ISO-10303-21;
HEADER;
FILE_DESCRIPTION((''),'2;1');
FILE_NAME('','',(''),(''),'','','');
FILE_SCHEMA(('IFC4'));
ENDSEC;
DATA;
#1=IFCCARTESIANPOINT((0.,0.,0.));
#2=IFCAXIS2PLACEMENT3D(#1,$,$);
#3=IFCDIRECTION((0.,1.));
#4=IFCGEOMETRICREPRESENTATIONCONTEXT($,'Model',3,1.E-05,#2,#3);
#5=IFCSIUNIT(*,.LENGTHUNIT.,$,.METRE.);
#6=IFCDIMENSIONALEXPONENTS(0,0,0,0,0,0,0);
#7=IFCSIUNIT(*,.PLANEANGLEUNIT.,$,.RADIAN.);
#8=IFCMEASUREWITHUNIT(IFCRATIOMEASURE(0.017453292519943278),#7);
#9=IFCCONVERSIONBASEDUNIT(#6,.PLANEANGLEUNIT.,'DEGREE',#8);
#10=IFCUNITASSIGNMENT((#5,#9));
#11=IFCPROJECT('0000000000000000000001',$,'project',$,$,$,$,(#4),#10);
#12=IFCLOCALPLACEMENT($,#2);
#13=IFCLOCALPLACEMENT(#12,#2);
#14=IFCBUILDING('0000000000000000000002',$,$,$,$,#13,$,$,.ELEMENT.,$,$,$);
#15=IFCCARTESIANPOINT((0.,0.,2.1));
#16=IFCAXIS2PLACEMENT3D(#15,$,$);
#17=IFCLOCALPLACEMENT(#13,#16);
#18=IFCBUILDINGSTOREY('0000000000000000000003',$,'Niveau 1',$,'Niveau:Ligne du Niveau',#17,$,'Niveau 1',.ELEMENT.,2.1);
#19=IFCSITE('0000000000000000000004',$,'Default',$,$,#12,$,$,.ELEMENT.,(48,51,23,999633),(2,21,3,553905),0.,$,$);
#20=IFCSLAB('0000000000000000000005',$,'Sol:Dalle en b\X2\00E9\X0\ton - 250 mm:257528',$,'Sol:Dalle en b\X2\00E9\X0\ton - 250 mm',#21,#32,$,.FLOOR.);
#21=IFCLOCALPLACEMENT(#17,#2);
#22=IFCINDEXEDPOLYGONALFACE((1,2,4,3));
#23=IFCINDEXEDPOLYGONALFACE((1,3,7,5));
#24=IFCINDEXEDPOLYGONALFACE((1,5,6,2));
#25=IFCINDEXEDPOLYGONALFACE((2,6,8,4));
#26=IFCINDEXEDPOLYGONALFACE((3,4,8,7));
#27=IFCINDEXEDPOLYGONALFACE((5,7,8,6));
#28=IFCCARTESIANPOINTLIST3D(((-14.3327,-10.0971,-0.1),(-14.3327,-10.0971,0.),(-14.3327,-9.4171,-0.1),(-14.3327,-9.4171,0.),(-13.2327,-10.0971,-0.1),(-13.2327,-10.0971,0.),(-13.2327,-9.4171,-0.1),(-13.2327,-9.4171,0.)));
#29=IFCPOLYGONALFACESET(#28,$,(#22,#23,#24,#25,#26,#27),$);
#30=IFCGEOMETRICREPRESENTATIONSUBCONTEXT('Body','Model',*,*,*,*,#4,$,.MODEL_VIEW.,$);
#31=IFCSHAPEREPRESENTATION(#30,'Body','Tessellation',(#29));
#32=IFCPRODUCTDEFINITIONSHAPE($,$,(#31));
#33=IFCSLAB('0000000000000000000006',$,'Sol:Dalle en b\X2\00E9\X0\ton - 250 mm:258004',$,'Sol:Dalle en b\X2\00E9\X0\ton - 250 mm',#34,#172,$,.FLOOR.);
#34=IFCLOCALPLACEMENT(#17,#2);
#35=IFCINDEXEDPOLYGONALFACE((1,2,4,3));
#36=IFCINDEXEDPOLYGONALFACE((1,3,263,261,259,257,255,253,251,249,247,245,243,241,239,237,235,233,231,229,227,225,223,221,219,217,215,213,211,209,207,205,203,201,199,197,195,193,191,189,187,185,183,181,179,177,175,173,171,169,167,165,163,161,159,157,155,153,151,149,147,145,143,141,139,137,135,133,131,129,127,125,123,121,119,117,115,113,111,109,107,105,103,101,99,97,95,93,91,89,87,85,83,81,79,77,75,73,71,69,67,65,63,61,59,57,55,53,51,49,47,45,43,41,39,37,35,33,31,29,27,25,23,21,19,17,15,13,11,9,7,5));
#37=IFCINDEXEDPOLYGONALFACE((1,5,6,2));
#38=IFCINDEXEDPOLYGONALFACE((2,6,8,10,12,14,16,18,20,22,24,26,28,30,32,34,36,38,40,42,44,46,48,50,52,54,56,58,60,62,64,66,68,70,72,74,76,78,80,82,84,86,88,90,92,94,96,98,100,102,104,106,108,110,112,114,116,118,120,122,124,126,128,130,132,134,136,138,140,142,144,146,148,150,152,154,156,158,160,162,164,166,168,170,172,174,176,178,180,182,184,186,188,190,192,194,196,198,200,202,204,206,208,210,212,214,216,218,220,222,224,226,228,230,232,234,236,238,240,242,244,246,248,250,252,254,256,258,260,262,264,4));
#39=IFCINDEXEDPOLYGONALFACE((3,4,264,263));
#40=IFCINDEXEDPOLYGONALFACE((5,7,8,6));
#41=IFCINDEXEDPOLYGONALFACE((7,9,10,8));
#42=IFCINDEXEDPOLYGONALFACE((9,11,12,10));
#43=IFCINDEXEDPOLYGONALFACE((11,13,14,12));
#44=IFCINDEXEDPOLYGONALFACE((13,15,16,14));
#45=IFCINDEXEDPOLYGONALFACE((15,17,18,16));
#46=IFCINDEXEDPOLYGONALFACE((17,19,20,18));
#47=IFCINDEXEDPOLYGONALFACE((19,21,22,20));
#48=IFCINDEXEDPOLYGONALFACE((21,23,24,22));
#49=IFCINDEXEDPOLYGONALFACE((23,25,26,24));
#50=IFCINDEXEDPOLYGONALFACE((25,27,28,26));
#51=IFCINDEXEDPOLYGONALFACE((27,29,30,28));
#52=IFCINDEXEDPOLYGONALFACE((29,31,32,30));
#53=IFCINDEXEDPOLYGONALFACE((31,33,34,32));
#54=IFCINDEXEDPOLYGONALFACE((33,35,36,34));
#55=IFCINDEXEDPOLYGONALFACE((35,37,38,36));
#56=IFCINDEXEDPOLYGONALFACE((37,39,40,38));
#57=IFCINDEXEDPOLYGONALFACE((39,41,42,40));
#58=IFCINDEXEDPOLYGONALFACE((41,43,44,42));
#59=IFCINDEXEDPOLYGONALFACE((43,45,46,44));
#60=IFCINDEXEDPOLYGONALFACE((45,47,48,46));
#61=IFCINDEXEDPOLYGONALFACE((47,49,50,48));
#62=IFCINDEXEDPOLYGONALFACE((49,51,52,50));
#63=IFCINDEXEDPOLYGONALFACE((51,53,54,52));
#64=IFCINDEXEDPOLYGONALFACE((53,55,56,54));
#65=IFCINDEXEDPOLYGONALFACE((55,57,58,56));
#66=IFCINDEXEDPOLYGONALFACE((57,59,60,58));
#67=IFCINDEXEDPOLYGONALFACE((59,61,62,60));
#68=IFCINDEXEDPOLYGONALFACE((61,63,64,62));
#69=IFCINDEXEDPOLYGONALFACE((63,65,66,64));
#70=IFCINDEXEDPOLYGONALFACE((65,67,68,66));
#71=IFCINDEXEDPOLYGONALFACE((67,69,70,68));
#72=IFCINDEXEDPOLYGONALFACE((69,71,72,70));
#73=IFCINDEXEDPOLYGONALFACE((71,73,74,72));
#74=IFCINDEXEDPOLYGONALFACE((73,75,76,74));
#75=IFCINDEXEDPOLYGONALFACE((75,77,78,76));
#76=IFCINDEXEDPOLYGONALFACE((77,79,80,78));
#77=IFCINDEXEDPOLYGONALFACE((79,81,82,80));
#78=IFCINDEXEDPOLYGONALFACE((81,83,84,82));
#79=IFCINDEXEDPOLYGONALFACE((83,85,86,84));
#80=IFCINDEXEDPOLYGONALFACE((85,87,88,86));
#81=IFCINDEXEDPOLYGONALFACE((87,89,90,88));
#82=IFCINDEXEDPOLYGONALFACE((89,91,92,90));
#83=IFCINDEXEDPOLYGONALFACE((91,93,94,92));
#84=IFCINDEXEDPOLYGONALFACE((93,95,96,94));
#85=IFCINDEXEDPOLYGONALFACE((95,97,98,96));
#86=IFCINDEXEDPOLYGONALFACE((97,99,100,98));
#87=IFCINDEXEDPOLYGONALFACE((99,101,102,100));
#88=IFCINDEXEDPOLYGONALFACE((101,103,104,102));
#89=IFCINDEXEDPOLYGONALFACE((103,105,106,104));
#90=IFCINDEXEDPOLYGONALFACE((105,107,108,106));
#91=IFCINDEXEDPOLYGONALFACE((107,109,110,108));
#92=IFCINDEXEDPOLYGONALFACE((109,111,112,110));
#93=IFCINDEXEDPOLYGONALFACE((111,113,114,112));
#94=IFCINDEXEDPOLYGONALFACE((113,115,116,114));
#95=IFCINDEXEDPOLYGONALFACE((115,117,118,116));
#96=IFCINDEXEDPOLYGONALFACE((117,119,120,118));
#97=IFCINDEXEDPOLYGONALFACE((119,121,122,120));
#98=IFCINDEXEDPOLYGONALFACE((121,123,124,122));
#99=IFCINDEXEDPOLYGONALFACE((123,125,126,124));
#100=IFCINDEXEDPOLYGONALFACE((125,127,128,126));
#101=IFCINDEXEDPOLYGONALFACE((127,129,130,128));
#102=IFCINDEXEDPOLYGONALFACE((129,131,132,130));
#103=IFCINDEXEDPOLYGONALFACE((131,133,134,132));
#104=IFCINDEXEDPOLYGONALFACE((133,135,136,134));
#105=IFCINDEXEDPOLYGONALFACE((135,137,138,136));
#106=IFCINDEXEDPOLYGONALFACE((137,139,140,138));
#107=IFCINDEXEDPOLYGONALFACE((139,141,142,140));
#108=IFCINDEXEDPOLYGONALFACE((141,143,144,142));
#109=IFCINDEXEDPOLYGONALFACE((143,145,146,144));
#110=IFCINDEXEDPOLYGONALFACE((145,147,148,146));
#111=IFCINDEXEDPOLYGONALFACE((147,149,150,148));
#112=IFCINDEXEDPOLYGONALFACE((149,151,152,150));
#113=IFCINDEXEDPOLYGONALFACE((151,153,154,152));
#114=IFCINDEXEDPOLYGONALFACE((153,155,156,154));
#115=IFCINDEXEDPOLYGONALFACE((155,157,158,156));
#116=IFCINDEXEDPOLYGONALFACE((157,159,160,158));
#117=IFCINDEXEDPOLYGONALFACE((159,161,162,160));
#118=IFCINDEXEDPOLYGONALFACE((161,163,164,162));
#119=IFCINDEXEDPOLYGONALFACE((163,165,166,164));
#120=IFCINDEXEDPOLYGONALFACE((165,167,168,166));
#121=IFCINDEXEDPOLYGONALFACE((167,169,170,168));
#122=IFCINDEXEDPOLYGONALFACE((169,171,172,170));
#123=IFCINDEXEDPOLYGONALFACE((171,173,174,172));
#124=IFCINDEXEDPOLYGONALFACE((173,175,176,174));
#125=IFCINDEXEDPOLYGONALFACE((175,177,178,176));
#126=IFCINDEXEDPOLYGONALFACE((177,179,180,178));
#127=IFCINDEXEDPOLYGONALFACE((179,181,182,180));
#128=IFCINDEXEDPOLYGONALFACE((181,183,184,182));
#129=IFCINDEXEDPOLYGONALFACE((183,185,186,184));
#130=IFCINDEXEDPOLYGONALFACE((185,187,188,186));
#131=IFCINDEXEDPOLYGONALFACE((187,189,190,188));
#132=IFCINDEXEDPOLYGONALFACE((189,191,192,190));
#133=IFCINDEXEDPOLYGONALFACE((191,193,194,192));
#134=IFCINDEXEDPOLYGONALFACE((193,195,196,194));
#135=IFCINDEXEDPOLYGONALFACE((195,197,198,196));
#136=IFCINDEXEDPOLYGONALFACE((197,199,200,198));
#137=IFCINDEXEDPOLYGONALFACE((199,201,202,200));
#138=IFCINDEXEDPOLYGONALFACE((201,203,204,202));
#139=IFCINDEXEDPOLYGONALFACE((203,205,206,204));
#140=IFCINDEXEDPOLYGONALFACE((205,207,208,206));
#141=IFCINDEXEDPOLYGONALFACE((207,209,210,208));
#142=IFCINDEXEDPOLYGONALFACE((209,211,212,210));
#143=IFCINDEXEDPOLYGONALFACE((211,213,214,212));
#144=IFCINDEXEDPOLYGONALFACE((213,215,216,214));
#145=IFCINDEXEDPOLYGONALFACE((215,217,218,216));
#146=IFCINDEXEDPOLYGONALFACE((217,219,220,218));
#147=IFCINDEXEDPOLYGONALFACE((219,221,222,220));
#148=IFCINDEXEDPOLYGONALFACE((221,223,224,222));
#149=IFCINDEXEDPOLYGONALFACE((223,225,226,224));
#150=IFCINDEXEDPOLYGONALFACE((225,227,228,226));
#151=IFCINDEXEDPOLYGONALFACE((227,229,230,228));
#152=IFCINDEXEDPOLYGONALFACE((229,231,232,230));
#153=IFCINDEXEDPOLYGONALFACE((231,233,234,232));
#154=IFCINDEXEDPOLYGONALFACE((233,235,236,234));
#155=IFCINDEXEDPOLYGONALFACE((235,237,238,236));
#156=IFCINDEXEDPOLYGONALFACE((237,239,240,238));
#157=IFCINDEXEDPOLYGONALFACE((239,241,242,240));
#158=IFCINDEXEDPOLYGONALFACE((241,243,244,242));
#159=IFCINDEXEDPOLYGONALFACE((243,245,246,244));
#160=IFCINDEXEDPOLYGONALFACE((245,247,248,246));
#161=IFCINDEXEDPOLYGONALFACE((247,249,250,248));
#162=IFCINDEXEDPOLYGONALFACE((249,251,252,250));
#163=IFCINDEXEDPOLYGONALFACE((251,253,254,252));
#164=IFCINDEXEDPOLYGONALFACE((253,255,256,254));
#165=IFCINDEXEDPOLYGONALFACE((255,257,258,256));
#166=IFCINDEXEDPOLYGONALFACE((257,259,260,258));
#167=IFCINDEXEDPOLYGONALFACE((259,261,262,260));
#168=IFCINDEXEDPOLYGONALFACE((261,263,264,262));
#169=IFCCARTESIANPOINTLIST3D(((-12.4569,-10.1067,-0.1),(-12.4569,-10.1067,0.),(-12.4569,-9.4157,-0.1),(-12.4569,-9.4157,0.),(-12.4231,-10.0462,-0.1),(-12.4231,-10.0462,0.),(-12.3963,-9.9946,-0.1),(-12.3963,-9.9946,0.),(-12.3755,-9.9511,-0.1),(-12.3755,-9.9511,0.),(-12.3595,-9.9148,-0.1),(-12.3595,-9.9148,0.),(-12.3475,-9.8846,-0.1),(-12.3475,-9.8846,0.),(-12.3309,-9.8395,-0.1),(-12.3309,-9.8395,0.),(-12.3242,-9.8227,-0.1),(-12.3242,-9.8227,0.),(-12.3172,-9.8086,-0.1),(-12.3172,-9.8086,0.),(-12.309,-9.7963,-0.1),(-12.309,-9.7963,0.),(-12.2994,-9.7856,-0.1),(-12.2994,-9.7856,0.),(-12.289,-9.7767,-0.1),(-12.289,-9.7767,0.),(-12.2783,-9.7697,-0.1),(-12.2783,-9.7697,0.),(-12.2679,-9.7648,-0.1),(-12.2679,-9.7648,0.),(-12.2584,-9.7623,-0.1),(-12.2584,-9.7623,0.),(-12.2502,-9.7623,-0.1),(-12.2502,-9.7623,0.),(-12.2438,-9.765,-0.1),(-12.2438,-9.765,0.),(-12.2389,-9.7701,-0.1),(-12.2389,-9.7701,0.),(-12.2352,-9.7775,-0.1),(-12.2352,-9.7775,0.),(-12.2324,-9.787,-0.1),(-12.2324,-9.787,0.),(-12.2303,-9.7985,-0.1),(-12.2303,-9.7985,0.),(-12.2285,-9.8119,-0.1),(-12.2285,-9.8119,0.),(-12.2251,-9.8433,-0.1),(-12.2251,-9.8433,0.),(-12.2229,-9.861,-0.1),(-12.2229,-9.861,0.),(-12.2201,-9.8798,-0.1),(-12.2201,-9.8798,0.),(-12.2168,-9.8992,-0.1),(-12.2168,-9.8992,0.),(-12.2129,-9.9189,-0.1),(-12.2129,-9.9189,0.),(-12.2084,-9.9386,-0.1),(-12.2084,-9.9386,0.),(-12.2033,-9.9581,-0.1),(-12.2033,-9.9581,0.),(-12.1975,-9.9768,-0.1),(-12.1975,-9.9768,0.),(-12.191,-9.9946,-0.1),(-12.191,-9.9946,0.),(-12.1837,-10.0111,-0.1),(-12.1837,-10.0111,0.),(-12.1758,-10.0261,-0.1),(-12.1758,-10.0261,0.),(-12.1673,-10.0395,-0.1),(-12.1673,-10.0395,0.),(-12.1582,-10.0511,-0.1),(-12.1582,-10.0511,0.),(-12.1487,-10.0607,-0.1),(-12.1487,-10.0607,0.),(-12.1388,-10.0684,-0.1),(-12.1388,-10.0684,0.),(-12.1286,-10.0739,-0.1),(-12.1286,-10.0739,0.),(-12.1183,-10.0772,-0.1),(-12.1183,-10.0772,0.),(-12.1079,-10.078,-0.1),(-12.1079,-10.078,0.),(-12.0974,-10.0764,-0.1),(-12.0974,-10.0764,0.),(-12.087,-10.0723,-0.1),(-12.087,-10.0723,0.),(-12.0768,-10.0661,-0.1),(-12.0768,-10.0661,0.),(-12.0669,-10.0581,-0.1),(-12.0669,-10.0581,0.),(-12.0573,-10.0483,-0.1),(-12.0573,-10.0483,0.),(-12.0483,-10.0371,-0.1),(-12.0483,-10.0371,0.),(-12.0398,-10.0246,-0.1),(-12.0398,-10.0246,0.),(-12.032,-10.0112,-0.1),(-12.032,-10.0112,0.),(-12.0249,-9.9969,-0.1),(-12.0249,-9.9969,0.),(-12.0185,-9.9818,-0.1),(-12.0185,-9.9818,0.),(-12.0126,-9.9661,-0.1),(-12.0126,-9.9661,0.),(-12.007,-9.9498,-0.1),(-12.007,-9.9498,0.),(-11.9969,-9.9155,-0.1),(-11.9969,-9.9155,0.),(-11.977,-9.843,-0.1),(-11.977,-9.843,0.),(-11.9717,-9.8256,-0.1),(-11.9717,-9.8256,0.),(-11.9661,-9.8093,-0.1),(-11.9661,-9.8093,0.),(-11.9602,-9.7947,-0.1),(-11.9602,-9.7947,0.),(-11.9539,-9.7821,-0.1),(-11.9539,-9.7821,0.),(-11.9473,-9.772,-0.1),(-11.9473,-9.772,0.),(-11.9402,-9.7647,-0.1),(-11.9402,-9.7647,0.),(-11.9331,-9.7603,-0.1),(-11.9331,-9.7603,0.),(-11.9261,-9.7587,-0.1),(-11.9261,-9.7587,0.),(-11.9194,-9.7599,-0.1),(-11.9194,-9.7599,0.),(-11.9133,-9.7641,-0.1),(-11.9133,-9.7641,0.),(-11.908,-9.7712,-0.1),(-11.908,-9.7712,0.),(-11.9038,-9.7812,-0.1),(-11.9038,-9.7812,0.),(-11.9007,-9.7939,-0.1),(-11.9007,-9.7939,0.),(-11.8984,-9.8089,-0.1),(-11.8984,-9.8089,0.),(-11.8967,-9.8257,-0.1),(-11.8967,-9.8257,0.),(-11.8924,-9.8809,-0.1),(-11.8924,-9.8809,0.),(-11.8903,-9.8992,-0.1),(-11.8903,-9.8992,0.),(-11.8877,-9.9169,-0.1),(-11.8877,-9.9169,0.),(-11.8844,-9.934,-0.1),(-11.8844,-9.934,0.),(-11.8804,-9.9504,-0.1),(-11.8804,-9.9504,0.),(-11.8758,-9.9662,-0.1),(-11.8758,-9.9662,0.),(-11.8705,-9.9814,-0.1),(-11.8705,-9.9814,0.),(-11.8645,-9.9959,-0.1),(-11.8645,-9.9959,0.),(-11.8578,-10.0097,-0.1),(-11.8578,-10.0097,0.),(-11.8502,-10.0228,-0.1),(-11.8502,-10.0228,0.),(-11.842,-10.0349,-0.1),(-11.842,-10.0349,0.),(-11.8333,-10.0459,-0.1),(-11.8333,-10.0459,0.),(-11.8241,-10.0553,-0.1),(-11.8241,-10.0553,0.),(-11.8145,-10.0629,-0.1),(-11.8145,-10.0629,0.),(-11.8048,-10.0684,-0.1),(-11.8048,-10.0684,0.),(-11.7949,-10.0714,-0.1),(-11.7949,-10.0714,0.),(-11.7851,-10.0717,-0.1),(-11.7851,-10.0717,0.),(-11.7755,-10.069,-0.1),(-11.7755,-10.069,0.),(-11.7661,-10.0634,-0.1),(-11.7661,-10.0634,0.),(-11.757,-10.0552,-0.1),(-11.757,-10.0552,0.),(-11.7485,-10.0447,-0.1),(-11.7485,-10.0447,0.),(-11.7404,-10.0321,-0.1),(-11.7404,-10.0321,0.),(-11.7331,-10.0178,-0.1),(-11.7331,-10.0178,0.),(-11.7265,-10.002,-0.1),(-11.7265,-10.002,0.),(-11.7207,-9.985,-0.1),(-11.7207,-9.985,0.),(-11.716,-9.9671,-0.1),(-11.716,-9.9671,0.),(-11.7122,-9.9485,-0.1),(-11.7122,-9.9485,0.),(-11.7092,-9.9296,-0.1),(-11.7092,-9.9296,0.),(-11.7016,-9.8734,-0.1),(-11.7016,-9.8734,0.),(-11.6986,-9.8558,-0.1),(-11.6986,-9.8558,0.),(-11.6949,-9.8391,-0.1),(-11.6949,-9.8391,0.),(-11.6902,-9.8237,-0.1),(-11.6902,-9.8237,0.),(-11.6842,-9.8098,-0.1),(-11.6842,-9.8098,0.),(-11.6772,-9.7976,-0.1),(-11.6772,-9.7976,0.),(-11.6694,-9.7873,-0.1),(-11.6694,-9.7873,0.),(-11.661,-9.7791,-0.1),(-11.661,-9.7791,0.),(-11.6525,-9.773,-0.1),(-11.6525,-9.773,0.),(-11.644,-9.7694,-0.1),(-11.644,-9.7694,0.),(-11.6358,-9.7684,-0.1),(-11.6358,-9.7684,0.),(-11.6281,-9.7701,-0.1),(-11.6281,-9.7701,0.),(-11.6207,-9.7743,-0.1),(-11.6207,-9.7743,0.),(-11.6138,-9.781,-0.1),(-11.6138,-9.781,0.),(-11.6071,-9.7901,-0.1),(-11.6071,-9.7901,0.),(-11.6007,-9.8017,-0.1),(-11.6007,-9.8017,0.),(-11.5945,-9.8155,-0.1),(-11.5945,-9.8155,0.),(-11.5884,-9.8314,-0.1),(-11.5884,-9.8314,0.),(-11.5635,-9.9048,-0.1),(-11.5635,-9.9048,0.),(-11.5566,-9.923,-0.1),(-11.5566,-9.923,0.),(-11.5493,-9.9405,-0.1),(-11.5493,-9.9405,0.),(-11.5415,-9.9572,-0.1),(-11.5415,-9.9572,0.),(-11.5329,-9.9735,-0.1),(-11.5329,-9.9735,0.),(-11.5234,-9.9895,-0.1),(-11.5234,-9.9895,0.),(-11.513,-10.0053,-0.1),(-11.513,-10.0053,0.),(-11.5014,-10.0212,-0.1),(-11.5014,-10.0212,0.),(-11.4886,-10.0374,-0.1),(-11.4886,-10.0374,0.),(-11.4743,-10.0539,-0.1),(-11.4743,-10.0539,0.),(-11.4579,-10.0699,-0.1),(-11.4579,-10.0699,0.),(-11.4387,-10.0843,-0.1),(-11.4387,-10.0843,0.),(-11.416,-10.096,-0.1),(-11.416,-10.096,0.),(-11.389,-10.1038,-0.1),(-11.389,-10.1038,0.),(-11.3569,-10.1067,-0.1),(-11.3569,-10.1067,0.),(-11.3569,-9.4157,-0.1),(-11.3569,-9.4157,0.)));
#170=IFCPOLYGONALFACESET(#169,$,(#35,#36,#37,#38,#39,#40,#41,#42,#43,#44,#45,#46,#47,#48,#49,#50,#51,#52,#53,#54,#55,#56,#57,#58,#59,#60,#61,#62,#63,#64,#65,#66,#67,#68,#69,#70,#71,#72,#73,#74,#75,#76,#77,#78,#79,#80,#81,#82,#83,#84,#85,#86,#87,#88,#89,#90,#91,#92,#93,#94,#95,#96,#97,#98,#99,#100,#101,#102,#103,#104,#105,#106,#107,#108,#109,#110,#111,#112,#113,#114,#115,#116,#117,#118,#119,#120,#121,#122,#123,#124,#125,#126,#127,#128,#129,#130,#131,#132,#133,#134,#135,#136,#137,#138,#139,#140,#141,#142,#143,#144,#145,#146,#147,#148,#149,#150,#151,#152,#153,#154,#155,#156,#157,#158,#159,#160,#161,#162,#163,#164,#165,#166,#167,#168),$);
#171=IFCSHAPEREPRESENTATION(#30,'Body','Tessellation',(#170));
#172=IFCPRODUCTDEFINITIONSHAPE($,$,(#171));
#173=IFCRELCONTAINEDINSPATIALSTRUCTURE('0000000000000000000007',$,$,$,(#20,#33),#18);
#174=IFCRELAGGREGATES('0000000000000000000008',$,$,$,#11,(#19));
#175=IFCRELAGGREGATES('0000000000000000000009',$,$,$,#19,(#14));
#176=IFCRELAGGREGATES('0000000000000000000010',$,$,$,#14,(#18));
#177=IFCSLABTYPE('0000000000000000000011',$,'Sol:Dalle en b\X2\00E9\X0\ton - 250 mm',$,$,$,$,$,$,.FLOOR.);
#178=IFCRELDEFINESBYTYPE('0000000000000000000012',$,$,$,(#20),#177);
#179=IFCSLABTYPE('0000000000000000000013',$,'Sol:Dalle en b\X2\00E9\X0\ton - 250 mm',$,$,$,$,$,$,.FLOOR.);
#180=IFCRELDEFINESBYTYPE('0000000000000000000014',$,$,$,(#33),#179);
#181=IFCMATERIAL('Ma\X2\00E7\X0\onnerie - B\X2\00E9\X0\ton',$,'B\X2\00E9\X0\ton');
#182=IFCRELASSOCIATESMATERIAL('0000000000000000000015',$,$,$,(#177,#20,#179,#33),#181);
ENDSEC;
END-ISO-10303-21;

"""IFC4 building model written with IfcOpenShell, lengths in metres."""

from ifc_helpers import new_model, entity, si_unit, converted_unit, direction, frame, origin, place, context, subcontext, project, spatial, indexed_curve, outline, extrude, material, type_object, element, save


model = new_model("IFC4")

# Units and contexts
model_context = context("Model", 3, precision=1e-05, world=origin(), true_north=direction((0.0, 1.0)))
body_context = subcontext(model_context, "Body", "Model", "MODEL_VIEW")
ifc_project = project(units=[si_unit("LENGTHUNIT", "METRE"), converted_unit("PLANEANGLEUNIT", "DEGREE", entity("IfcRatioMeasure", 0.017453292519943278), si_unit("PLANEANGLEUNIT", "RADIAN"), dimensions=[0, 0, 0, 0, 0, 0, 0])], contexts=[model_context])

# Site, building, storey
site_placement = place(None, origin())
site = spatial("IfcSite", under=ifc_project, at=site_placement, Name="Default", CompositionType="ELEMENT", RefLatitude=(48, 51, 23, 999633), RefLongitude=(2, 21, 3, 553905), RefElevation=0.0)
building_placement = place(site_placement, origin())
building = spatial("IfcBuilding", under=site, at=building_placement, CompositionType="ELEMENT")
storey_placement = place(building_placement, frame((0.0, 0.0, 2.1)))
storey = spatial("IfcBuildingStorey", under=building, at=storey_placement, Name="Niveau 1", ObjectType="Niveau:Ligne du Niveau", LongName="Niveau 1", CompositionType="ELEMENT", Elevation=2.1)

# Slabs
ifc_material = material(Name="Maçonnerie - Béton", Category="Béton")
slab_type_1 = type_object("IfcSlabType", Name="Sol:Dalle en béton - 250 mm", PredefinedType="FLOOR", material=ifc_material)
slab_1_placement = place(storey_placement, origin())
element("IfcSlab", 1, at=slab_1_placement, inside=storey, type_object=slab_type_1, material=ifc_material, Name="Sol:Dalle en béton - 250 mm:257528", ObjectType="Sol:Dalle en béton - 250 mm", PredefinedType="FLOOR", context=body_context, shape_type="SweptSolid", body=[
    extrude(outline(indexed_curve([(-0.34, -0.55), (0.34, -0.55), (0.34, 0.55), (-0.34, 0.55), (-0.34, -0.55)], self_intersect=False)), frame((-13.7827, -9.7571, 0.0), z_axis=(0.0, 0.0, -1.0), x_axis=(0.0, 1.0, 0.0)), (0.0, 0.0, 1.0), 0.1),
])
slab_type_2 = type_object("IfcSlabType", Name="Sol:Dalle en béton - 250 mm", PredefinedType="FLOOR", material=ifc_material)
slab_2_placement = place(storey_placement, origin())
element("IfcSlab", 2, at=slab_2_placement, inside=storey, type_object=slab_type_2, material=ifc_material, Name="Sol:Dalle en béton - 250 mm:258004", ObjectType="Sol:Dalle en béton - 250 mm", PredefinedType="FLOOR", context=body_context, shape_type="SweptSolid", body=[
    extrude(outline(indexed_curve([(-0.5617, -0.4951), (0.5383, -0.4951), (0.5383, 0.1959), (0.5045, 0.1354), (0.4777, 0.0839), (0.4569, 0.0404), (0.441, 0.004), (0.4289, -0.0261), (0.4123, -0.0713), (0.4056, -0.088), (0.3987, -0.1021), (0.3904, -0.1144), (0.3808, -0.1251), (0.3704, -0.1341), (0.3597, -0.1411), (0.3494, -0.1459), (0.3398, -0.1484), (0.3317, -0.1484), (0.3252, -0.1458), (0.3203, -0.1407), (0.3166, -0.1333), (0.3138, -0.1238), (0.3117, -0.1122), (0.31, -0.0989), (0.3065, -0.0675), (0.3043, -0.0497), (0.3015, -0.031), (0.2982, -0.0116), (0.2944, 0.0081), (0.2899, 0.0279), (0.2847, 0.0473), (0.2789, 0.0661), (0.2724, 0.0839), (0.2652, 0.1004), (0.2572, 0.1153), (0.2487, 0.1287), (0.2396, 0.1403), (0.2301, 0.15), (0.2202, 0.1576), (0.2101, 0.1632), (0.1997, 0.1664), (0.1893, 0.1672), (0.1788, 0.1656), (0.1684, 0.1615), (0.1582, 0.1554), (0.1483, 0.1473), (0.1388, 0.1375), (0.1297, 0.1263), (0.1212, 0.1138), (0.1134, 0.1004), (0.1064, 0.0861), (0.0999, 0.0711), (0.094, 0.0553), (0.0885, 0.039), (0.0783, 0.0047), (0.0584, -0.0678), (0.0531, -0.0852), (0.0475, -0.1015), (0.0416, -0.1161), (0.0354, -0.1287), (0.0287, -0.1388), (0.0217, -0.146), (0.0145, -0.1505), (0.0075, -0.1521), (0.0008, -0.1508), (-0.0053, -0.1467), (-0.0105, -0.1396), (-0.0148, -0.1296), (-0.0179, -0.1168), (-0.0202, -0.1018), (-0.0219, -0.0851), (-0.0262, -0.0299), (-0.0282, -0.0116), (-0.0309, 0.0061), (-0.0342, 0.0232), (-0.0381, 0.0397), (-0.0427, 0.0555), (-0.048, 0.0706), (-0.0541, 0.0851), (-0.0608, 0.0989), (-0.0683, 0.112), (-0.0765, 0.1242), (-0.0853, 0.1351), (-0.0945, 0.1445), (-0.1041, 0.1521), (-0.1138, 0.1576), (-0.1236, 0.1606), (-0.1334, 0.1609), (-0.1431, 0.1583), (-0.1525, 0.1527), (-0.1615, 0.1445), (-0.1701, 0.1339), (-0.1781, 0.1214), (-0.1855, 0.107), (-0.1921, 0.0912), (-0.1978, 0.0742), (-0.2026, 0.0563), (-0.2064, 0.0378), (-0.2094, 0.0189), (-0.2169, -0.0373), (-0.2199, -0.055), (-0.2236, -0.0716), (-0.2284, -0.0871), (-0.2343, -0.101), (-0.2414, -0.1132), (-0.2492, -0.1235), (-0.2576, -0.1317), (-0.2661, -0.1377), (-0.2746, -0.1413), (-0.2828, -0.1423), (-0.2905, -0.1407), (-0.2978, -0.1365), (-0.3048, -0.1298), (-0.3115, -0.1206), (-0.3179, -0.1091), (-0.3241, -0.0952), (-0.3302, -0.0794), (-0.3551, -0.006), (-0.3619, 0.0123), (-0.3692, 0.0297), (-0.3771, 0.0465), (-0.3857, 0.0627), (-0.3952, 0.0787), (-0.4056, 0.0945), (-0.4172, 0.1105), (-0.43, 0.1266), (-0.4443, 0.1431), (-0.4607, 0.1591), (-0.4799, 0.1735), (-0.5026, 0.1852), (-0.5296, 0.193), (-0.5617, 0.1959), (-0.5617, -0.4951)], self_intersect=False)), frame((-11.9186, -9.9108, -0.1), z_axis=(0.0, 0.0, 1.0), x_axis=(-1.0, 0.0, 0.0)), (0.0, 0.0, 1.0), 0.1),
])

save(model, "model.ifc")
